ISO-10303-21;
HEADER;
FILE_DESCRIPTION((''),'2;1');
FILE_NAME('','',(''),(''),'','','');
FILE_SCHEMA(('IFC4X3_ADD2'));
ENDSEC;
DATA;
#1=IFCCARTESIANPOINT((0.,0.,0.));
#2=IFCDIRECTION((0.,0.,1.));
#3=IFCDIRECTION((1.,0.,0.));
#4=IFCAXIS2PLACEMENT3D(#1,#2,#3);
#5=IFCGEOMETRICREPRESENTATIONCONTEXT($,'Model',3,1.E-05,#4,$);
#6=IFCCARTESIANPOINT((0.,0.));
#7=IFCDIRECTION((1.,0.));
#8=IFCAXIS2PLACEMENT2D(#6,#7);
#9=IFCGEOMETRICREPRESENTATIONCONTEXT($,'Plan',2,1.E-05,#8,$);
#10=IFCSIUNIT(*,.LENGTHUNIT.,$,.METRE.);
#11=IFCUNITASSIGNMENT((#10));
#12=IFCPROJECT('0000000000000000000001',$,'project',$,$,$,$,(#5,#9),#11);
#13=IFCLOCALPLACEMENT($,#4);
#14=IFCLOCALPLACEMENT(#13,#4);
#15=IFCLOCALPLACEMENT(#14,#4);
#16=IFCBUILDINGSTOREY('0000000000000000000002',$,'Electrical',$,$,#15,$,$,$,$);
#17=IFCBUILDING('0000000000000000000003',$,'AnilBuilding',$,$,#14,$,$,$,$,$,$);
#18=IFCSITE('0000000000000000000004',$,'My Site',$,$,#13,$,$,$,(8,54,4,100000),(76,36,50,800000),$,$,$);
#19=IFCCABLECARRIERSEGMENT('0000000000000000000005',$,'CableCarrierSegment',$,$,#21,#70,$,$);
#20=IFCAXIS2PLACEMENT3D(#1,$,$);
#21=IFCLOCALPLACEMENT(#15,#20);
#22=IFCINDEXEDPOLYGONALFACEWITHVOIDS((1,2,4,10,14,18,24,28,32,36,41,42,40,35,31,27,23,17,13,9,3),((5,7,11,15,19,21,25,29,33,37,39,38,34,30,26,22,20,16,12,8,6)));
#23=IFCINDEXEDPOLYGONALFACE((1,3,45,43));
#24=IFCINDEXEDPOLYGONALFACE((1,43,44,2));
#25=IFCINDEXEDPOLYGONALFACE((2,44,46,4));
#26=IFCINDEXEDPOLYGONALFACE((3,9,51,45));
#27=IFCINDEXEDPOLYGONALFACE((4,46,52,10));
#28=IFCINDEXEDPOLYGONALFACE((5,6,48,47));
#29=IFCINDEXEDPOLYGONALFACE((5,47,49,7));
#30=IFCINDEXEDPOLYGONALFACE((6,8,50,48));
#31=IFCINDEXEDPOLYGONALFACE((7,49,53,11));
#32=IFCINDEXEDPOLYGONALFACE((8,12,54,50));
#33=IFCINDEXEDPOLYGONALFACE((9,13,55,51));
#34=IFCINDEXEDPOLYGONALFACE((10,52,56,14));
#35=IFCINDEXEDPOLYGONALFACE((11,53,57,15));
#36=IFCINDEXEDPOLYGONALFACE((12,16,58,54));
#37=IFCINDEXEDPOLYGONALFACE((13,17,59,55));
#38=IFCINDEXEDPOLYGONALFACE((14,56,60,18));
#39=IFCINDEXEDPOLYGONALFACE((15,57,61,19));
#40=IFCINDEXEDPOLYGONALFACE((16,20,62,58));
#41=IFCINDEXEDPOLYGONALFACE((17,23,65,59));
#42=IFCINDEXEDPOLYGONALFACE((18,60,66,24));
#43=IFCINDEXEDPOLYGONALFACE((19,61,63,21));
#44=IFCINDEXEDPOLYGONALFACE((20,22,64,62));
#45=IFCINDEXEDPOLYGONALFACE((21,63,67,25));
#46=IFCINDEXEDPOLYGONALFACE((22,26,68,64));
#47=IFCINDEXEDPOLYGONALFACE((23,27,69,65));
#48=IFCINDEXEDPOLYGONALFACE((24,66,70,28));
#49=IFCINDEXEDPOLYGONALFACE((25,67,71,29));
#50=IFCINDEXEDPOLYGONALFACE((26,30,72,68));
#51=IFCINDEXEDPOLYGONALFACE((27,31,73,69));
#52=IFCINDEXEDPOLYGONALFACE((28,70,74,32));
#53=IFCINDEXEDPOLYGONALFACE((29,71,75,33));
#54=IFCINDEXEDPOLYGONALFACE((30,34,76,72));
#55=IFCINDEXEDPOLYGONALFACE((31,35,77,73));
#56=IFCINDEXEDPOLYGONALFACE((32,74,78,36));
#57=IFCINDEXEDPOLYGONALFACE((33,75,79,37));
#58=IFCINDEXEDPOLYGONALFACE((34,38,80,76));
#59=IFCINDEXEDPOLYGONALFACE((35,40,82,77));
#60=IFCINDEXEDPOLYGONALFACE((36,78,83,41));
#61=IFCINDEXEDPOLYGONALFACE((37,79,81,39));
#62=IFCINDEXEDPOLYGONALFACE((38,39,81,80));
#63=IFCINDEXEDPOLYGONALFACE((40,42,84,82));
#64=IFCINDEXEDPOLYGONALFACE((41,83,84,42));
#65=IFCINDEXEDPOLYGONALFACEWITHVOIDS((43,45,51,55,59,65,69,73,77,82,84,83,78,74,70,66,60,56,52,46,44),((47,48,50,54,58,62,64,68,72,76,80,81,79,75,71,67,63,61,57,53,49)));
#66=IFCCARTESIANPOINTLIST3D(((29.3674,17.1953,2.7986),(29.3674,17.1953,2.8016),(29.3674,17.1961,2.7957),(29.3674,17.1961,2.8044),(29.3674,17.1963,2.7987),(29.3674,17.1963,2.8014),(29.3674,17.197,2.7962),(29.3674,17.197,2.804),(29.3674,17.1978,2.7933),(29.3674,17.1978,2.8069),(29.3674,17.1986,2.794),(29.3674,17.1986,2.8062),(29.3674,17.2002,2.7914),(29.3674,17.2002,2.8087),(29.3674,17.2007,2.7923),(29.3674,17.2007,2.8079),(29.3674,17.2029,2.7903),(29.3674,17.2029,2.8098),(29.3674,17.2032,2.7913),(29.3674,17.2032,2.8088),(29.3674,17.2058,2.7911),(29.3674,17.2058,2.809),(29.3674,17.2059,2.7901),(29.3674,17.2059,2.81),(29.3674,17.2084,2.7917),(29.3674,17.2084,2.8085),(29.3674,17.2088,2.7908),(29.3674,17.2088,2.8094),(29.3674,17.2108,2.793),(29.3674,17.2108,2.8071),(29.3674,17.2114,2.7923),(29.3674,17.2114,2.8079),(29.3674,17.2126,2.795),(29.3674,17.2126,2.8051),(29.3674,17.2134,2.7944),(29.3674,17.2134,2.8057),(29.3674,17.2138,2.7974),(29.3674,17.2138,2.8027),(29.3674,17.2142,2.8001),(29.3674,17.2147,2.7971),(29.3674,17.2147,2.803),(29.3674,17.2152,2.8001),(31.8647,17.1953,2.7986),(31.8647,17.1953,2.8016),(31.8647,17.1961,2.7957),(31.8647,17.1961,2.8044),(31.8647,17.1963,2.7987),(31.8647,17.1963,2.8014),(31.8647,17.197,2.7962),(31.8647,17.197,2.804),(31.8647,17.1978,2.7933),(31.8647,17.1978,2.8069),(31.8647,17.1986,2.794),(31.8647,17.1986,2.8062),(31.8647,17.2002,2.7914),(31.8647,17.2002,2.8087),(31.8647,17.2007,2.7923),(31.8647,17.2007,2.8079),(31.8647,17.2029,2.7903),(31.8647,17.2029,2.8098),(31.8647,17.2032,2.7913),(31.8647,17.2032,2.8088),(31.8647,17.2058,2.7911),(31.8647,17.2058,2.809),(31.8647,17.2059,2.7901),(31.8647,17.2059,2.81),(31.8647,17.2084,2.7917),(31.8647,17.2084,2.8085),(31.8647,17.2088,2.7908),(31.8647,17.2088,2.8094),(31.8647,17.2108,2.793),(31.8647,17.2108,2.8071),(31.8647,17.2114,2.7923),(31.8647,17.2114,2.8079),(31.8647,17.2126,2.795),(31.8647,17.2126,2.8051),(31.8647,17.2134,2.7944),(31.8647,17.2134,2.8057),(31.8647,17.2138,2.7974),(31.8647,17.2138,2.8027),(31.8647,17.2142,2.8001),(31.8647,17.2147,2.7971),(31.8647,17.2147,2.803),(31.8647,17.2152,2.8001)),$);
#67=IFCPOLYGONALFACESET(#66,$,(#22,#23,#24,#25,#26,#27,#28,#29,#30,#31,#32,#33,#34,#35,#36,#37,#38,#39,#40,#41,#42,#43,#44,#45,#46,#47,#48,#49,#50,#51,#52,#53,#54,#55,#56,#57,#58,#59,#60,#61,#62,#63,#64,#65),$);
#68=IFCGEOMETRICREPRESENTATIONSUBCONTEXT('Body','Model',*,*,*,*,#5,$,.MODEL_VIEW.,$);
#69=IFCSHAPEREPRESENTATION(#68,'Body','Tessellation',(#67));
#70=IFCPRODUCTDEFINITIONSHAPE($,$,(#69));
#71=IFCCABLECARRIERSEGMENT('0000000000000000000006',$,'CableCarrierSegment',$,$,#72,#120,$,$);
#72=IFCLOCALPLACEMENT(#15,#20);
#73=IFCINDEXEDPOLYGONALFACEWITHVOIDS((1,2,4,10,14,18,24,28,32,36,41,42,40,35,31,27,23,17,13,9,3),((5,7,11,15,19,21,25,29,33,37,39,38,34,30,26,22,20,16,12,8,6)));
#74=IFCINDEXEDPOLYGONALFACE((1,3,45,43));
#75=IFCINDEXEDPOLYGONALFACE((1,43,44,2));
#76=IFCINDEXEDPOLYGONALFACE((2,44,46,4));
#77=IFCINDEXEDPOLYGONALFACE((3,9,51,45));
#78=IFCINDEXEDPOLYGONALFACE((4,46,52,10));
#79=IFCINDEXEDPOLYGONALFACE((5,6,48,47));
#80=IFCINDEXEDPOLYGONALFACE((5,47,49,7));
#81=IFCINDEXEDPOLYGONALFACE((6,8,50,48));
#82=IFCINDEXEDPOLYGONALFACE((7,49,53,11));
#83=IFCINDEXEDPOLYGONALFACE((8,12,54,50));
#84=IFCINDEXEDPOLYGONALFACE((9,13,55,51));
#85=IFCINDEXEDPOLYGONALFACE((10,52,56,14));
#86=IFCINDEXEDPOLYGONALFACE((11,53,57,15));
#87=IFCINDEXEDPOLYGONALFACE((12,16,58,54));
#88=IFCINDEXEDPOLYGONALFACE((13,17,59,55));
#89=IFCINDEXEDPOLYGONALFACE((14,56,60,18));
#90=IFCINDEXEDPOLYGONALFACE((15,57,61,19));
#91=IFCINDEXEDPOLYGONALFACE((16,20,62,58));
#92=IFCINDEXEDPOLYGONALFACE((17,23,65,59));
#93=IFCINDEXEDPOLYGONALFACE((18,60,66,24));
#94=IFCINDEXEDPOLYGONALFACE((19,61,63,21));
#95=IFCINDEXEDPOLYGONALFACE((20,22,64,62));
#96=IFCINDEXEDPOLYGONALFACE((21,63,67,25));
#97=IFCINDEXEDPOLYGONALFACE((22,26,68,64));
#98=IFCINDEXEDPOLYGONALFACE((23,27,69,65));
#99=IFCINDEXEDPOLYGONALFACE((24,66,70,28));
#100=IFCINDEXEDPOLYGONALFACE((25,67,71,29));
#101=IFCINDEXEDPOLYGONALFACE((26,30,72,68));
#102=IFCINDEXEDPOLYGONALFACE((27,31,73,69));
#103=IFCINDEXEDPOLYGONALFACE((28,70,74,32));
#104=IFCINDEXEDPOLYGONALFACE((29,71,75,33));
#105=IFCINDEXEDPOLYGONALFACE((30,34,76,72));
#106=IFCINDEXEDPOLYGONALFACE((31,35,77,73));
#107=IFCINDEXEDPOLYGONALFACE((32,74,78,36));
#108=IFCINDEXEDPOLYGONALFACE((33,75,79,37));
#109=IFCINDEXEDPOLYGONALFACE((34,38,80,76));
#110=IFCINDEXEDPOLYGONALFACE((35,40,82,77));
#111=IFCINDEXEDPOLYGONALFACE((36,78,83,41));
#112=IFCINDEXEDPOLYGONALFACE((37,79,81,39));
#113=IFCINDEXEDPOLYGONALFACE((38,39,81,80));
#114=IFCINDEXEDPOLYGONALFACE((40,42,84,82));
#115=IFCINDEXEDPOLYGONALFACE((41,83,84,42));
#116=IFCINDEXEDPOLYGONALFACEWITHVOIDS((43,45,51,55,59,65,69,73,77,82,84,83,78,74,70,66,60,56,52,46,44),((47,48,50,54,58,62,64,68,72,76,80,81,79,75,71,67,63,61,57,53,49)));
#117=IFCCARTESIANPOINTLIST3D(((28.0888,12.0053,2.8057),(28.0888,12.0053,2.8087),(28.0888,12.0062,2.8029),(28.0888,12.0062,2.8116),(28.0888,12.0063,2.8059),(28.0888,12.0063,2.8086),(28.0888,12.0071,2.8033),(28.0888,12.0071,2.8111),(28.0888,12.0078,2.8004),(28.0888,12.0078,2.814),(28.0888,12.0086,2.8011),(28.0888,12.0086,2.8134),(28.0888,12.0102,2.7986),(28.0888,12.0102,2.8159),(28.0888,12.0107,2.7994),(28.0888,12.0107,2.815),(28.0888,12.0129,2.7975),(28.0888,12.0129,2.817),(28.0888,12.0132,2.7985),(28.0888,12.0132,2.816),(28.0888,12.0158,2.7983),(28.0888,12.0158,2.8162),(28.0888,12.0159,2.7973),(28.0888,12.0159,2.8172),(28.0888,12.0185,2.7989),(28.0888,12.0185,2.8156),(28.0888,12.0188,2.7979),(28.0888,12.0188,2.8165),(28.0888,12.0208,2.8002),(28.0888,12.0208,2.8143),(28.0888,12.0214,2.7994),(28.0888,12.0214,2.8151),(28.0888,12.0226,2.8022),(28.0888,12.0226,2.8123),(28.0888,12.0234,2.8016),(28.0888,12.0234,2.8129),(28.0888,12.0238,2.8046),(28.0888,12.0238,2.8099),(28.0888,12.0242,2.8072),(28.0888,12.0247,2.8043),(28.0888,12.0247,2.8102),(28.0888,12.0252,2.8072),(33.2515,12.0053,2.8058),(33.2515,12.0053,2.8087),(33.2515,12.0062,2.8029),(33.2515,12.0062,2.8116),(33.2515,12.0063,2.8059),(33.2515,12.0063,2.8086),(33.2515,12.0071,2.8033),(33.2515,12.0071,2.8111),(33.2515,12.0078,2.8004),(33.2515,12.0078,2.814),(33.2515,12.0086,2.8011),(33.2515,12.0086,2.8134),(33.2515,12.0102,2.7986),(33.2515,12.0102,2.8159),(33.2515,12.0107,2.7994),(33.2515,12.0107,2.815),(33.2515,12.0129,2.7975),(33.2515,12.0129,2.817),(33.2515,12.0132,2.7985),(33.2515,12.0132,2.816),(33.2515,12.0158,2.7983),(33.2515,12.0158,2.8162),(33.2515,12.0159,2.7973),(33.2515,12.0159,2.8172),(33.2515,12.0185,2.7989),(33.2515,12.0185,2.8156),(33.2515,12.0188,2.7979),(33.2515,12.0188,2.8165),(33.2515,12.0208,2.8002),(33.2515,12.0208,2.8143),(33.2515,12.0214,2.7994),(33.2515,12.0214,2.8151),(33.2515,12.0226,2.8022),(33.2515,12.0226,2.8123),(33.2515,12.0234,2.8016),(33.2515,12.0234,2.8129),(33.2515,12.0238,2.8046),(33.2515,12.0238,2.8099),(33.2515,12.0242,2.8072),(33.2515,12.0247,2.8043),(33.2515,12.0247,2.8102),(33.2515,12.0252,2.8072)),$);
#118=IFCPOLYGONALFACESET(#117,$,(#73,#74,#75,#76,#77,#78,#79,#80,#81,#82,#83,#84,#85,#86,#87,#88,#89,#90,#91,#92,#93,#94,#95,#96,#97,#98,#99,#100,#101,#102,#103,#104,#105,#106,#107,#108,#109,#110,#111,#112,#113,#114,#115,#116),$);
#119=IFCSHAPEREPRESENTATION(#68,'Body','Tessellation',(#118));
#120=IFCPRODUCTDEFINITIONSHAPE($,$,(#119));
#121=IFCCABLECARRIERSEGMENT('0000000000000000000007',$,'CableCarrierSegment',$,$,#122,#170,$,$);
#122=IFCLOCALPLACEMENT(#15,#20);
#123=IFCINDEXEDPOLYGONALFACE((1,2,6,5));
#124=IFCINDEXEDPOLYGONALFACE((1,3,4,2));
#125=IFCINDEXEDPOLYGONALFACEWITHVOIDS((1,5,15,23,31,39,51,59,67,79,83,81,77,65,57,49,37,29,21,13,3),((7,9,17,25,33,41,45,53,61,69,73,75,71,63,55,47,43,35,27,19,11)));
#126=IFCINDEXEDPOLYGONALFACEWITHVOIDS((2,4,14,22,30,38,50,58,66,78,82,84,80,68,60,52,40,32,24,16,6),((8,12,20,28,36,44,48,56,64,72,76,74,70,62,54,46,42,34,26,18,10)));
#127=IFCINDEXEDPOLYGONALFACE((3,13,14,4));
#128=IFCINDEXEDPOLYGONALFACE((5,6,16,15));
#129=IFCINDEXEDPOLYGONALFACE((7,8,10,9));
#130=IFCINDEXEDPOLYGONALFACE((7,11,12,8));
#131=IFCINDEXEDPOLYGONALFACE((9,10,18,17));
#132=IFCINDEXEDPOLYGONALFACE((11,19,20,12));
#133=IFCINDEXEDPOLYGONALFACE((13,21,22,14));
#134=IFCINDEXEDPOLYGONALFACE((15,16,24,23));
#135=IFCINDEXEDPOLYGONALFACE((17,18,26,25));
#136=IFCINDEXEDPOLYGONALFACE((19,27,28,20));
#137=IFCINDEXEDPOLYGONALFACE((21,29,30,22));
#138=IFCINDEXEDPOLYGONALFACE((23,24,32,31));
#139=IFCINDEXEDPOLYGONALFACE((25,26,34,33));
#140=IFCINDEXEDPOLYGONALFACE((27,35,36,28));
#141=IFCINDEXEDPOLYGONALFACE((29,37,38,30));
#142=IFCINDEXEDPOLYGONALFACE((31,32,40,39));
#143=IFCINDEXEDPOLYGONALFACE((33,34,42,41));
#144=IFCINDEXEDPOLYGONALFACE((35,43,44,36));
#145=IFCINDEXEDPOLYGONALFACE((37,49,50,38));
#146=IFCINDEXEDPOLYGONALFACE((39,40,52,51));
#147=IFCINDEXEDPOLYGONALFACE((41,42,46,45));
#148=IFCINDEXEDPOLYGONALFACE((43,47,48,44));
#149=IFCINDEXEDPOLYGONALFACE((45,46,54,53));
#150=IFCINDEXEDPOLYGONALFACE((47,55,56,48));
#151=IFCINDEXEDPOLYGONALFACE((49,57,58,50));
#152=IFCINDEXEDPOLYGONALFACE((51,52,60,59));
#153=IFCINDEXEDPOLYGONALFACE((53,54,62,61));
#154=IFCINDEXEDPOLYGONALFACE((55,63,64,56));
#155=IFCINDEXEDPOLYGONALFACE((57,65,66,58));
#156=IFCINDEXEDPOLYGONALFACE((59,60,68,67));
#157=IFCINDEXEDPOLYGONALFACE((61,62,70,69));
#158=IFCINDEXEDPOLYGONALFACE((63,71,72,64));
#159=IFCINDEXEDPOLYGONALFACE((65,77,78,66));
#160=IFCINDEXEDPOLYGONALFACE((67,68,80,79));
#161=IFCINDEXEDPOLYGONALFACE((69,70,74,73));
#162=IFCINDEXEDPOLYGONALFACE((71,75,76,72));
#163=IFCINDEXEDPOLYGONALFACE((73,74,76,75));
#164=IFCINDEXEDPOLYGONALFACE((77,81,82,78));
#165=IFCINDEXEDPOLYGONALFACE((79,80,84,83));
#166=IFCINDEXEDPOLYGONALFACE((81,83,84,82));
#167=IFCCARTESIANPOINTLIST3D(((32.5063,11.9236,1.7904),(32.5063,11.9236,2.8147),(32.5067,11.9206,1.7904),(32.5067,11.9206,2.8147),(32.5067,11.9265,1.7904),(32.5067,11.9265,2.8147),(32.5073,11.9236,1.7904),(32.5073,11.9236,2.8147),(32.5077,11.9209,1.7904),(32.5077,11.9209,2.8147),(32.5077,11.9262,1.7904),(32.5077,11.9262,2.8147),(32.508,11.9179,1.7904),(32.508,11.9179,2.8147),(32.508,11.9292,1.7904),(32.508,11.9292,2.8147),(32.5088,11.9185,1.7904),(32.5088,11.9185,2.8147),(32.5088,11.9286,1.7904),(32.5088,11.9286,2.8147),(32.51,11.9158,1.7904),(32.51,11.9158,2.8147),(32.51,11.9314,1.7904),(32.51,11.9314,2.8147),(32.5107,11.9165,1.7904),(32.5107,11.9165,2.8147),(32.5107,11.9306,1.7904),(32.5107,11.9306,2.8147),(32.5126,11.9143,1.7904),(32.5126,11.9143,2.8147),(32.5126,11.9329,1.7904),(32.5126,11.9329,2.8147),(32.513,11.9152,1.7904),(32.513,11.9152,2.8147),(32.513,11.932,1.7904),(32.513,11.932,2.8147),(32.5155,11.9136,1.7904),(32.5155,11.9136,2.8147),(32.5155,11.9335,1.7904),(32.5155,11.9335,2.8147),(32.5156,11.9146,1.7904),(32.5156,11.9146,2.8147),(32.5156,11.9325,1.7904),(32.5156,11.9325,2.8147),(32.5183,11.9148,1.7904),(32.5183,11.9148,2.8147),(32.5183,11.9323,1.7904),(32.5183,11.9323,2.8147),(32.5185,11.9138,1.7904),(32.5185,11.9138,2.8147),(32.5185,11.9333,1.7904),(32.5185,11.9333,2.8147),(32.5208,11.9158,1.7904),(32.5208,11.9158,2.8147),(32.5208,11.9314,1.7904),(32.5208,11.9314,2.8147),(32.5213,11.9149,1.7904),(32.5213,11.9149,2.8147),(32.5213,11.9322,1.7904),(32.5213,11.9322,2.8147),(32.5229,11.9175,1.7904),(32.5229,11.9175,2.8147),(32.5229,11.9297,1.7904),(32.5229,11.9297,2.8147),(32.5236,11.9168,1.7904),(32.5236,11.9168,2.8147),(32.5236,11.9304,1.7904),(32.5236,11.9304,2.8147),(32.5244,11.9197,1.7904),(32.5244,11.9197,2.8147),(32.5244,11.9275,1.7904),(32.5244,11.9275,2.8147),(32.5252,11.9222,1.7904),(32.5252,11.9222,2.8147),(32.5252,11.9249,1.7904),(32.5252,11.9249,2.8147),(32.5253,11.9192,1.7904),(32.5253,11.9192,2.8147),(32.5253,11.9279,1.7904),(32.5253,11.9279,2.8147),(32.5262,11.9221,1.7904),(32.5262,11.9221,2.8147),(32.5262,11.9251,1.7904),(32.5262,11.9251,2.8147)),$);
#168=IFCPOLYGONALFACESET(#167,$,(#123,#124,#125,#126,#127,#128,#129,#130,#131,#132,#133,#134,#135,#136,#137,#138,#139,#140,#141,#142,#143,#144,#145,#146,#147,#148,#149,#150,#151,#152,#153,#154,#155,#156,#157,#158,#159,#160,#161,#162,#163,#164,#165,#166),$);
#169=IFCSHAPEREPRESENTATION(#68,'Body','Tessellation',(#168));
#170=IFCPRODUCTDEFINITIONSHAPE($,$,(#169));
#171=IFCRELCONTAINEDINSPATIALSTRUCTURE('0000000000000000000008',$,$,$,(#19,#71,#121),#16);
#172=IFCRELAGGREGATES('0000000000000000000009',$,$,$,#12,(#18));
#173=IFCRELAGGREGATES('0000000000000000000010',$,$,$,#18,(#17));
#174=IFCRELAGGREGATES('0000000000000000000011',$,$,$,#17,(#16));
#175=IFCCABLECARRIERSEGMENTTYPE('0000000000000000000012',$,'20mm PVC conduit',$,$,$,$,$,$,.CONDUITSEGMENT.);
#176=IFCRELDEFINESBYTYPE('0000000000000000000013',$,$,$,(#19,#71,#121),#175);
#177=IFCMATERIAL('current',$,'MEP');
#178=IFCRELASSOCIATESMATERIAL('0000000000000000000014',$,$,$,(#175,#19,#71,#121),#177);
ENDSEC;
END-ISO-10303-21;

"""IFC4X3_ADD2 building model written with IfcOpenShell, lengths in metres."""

from ifc_helpers import new_model, si_unit, frame, origin_with_axes, origin_2d_with_axis, place, context, subcontext, project, spatial, hollow_circle, extrude, material, material_profile, profile_set, profile_usage, type_object, element, save


model = new_model("IFC4X3_ADD2")

# Units and contexts
model_context = context("Model", 3, precision=1e-05, world=origin_with_axes())
plan_context = context("Plan", 2, precision=1e-05, world=origin_2d_with_axis())
body_context = subcontext(model_context, "Body", "Model", "MODEL_VIEW")
ifc_project = project(units=[si_unit("LENGTHUNIT", "METRE")], contexts=[model_context, plan_context])

# Site, building, storey
site_placement = place(None, origin_with_axes())
site = spatial("IfcSite", under=ifc_project, at=site_placement, Name="My Site", RefLatitude=(8, 54, 4, 100000), RefLongitude=(76, 36, 50, 800000))
building_placement = place(site_placement, origin_with_axes())
building = spatial("IfcBuilding", under=site, at=building_placement, Name="AnilBuilding")
storey_placement = place(building_placement, origin_with_axes())
storey = spatial("IfcBuildingStorey", under=building, at=storey_placement, Name="Electrical")

# Cable carrier segments
ifc_material = material(Name="current", Category="MEP")
ifc_material_profile_1 = material_profile(ifc_material, hollow_circle(Radius=0.01, WallThickness=0.001))
ifc_profile_set_1 = profile_set([ifc_material_profile_1], Name="current")
ifc_material_profile_2 = material_profile(ifc_material, hollow_circle(Radius=0.01, WallThickness=0.001))
ifc_profile_set_2 = profile_set([ifc_material_profile_2], Name="current")
cable_carrier_segment_type = type_object("IfcCableCarrierSegmentType", Name="20mm PVC conduit", PredefinedType="CONDUITSEGMENT", material=ifc_profile_set_2)
ifc_profile_usage_1 = profile_usage(ifc_profile_set_1, cardinal=5)
cable_carrier_segment_1_placement = place(storey_placement, frame((29.3674, 17.2052, 2.8001), z_axis=(1.0, 0.0, 0.0), x_axis=(0.0, 1.0, 0.0)))
element("IfcCableCarrierSegment", 1, at=cable_carrier_segment_1_placement, inside=storey, type_object=cable_carrier_segment_type, material=ifc_profile_usage_1, Name="CableCarrierSegment", context=body_context, shape_type="SweptSolid", body=[
    extrude(hollow_circle(Radius=0.01, WallThickness=0.001), origin_with_axes(), (0.0, 0.0, 1.0), 2.4973),
])
ifc_profile_usage_2 = profile_usage(ifc_profile_set_1, cardinal=5)
cable_carrier_segment_2_placement = place(storey_placement, frame((28.0888, 12.0152, 2.8072), z_axis=(1.0, 0.0, 0.0), x_axis=(0.0, 1.0, 0.0)))
element("IfcCableCarrierSegment", 2, at=cable_carrier_segment_2_placement, inside=storey, type_object=cable_carrier_segment_type, material=ifc_profile_usage_2, Name="CableCarrierSegment", context=body_context, shape_type="SweptSolid", body=[
    extrude(hollow_circle(Radius=0.01, WallThickness=0.001), origin_with_axes(), (0.0, 0.0, 1.0), 5.1627),
])
ifc_profile_usage_3 = profile_usage(ifc_profile_set_1, cardinal=5)
cable_carrier_segment_3_placement = place(storey_placement, frame((32.5163, 11.9236, 1.7904), z_axis=(0.0, 0.0, 1.0), x_axis=(-1.0, 0.0, 0.0)))
element("IfcCableCarrierSegment", 3, at=cable_carrier_segment_3_placement, inside=storey, type_object=cable_carrier_segment_type, material=ifc_profile_usage_3, Name="CableCarrierSegment", context=body_context, shape_type="SweptSolid", body=[
    extrude(hollow_circle(Radius=0.01, WallThickness=0.001), origin_with_axes(), (0.0, 0.0, 1.0), 1.0242),
])

save(model, "model.ifc")
